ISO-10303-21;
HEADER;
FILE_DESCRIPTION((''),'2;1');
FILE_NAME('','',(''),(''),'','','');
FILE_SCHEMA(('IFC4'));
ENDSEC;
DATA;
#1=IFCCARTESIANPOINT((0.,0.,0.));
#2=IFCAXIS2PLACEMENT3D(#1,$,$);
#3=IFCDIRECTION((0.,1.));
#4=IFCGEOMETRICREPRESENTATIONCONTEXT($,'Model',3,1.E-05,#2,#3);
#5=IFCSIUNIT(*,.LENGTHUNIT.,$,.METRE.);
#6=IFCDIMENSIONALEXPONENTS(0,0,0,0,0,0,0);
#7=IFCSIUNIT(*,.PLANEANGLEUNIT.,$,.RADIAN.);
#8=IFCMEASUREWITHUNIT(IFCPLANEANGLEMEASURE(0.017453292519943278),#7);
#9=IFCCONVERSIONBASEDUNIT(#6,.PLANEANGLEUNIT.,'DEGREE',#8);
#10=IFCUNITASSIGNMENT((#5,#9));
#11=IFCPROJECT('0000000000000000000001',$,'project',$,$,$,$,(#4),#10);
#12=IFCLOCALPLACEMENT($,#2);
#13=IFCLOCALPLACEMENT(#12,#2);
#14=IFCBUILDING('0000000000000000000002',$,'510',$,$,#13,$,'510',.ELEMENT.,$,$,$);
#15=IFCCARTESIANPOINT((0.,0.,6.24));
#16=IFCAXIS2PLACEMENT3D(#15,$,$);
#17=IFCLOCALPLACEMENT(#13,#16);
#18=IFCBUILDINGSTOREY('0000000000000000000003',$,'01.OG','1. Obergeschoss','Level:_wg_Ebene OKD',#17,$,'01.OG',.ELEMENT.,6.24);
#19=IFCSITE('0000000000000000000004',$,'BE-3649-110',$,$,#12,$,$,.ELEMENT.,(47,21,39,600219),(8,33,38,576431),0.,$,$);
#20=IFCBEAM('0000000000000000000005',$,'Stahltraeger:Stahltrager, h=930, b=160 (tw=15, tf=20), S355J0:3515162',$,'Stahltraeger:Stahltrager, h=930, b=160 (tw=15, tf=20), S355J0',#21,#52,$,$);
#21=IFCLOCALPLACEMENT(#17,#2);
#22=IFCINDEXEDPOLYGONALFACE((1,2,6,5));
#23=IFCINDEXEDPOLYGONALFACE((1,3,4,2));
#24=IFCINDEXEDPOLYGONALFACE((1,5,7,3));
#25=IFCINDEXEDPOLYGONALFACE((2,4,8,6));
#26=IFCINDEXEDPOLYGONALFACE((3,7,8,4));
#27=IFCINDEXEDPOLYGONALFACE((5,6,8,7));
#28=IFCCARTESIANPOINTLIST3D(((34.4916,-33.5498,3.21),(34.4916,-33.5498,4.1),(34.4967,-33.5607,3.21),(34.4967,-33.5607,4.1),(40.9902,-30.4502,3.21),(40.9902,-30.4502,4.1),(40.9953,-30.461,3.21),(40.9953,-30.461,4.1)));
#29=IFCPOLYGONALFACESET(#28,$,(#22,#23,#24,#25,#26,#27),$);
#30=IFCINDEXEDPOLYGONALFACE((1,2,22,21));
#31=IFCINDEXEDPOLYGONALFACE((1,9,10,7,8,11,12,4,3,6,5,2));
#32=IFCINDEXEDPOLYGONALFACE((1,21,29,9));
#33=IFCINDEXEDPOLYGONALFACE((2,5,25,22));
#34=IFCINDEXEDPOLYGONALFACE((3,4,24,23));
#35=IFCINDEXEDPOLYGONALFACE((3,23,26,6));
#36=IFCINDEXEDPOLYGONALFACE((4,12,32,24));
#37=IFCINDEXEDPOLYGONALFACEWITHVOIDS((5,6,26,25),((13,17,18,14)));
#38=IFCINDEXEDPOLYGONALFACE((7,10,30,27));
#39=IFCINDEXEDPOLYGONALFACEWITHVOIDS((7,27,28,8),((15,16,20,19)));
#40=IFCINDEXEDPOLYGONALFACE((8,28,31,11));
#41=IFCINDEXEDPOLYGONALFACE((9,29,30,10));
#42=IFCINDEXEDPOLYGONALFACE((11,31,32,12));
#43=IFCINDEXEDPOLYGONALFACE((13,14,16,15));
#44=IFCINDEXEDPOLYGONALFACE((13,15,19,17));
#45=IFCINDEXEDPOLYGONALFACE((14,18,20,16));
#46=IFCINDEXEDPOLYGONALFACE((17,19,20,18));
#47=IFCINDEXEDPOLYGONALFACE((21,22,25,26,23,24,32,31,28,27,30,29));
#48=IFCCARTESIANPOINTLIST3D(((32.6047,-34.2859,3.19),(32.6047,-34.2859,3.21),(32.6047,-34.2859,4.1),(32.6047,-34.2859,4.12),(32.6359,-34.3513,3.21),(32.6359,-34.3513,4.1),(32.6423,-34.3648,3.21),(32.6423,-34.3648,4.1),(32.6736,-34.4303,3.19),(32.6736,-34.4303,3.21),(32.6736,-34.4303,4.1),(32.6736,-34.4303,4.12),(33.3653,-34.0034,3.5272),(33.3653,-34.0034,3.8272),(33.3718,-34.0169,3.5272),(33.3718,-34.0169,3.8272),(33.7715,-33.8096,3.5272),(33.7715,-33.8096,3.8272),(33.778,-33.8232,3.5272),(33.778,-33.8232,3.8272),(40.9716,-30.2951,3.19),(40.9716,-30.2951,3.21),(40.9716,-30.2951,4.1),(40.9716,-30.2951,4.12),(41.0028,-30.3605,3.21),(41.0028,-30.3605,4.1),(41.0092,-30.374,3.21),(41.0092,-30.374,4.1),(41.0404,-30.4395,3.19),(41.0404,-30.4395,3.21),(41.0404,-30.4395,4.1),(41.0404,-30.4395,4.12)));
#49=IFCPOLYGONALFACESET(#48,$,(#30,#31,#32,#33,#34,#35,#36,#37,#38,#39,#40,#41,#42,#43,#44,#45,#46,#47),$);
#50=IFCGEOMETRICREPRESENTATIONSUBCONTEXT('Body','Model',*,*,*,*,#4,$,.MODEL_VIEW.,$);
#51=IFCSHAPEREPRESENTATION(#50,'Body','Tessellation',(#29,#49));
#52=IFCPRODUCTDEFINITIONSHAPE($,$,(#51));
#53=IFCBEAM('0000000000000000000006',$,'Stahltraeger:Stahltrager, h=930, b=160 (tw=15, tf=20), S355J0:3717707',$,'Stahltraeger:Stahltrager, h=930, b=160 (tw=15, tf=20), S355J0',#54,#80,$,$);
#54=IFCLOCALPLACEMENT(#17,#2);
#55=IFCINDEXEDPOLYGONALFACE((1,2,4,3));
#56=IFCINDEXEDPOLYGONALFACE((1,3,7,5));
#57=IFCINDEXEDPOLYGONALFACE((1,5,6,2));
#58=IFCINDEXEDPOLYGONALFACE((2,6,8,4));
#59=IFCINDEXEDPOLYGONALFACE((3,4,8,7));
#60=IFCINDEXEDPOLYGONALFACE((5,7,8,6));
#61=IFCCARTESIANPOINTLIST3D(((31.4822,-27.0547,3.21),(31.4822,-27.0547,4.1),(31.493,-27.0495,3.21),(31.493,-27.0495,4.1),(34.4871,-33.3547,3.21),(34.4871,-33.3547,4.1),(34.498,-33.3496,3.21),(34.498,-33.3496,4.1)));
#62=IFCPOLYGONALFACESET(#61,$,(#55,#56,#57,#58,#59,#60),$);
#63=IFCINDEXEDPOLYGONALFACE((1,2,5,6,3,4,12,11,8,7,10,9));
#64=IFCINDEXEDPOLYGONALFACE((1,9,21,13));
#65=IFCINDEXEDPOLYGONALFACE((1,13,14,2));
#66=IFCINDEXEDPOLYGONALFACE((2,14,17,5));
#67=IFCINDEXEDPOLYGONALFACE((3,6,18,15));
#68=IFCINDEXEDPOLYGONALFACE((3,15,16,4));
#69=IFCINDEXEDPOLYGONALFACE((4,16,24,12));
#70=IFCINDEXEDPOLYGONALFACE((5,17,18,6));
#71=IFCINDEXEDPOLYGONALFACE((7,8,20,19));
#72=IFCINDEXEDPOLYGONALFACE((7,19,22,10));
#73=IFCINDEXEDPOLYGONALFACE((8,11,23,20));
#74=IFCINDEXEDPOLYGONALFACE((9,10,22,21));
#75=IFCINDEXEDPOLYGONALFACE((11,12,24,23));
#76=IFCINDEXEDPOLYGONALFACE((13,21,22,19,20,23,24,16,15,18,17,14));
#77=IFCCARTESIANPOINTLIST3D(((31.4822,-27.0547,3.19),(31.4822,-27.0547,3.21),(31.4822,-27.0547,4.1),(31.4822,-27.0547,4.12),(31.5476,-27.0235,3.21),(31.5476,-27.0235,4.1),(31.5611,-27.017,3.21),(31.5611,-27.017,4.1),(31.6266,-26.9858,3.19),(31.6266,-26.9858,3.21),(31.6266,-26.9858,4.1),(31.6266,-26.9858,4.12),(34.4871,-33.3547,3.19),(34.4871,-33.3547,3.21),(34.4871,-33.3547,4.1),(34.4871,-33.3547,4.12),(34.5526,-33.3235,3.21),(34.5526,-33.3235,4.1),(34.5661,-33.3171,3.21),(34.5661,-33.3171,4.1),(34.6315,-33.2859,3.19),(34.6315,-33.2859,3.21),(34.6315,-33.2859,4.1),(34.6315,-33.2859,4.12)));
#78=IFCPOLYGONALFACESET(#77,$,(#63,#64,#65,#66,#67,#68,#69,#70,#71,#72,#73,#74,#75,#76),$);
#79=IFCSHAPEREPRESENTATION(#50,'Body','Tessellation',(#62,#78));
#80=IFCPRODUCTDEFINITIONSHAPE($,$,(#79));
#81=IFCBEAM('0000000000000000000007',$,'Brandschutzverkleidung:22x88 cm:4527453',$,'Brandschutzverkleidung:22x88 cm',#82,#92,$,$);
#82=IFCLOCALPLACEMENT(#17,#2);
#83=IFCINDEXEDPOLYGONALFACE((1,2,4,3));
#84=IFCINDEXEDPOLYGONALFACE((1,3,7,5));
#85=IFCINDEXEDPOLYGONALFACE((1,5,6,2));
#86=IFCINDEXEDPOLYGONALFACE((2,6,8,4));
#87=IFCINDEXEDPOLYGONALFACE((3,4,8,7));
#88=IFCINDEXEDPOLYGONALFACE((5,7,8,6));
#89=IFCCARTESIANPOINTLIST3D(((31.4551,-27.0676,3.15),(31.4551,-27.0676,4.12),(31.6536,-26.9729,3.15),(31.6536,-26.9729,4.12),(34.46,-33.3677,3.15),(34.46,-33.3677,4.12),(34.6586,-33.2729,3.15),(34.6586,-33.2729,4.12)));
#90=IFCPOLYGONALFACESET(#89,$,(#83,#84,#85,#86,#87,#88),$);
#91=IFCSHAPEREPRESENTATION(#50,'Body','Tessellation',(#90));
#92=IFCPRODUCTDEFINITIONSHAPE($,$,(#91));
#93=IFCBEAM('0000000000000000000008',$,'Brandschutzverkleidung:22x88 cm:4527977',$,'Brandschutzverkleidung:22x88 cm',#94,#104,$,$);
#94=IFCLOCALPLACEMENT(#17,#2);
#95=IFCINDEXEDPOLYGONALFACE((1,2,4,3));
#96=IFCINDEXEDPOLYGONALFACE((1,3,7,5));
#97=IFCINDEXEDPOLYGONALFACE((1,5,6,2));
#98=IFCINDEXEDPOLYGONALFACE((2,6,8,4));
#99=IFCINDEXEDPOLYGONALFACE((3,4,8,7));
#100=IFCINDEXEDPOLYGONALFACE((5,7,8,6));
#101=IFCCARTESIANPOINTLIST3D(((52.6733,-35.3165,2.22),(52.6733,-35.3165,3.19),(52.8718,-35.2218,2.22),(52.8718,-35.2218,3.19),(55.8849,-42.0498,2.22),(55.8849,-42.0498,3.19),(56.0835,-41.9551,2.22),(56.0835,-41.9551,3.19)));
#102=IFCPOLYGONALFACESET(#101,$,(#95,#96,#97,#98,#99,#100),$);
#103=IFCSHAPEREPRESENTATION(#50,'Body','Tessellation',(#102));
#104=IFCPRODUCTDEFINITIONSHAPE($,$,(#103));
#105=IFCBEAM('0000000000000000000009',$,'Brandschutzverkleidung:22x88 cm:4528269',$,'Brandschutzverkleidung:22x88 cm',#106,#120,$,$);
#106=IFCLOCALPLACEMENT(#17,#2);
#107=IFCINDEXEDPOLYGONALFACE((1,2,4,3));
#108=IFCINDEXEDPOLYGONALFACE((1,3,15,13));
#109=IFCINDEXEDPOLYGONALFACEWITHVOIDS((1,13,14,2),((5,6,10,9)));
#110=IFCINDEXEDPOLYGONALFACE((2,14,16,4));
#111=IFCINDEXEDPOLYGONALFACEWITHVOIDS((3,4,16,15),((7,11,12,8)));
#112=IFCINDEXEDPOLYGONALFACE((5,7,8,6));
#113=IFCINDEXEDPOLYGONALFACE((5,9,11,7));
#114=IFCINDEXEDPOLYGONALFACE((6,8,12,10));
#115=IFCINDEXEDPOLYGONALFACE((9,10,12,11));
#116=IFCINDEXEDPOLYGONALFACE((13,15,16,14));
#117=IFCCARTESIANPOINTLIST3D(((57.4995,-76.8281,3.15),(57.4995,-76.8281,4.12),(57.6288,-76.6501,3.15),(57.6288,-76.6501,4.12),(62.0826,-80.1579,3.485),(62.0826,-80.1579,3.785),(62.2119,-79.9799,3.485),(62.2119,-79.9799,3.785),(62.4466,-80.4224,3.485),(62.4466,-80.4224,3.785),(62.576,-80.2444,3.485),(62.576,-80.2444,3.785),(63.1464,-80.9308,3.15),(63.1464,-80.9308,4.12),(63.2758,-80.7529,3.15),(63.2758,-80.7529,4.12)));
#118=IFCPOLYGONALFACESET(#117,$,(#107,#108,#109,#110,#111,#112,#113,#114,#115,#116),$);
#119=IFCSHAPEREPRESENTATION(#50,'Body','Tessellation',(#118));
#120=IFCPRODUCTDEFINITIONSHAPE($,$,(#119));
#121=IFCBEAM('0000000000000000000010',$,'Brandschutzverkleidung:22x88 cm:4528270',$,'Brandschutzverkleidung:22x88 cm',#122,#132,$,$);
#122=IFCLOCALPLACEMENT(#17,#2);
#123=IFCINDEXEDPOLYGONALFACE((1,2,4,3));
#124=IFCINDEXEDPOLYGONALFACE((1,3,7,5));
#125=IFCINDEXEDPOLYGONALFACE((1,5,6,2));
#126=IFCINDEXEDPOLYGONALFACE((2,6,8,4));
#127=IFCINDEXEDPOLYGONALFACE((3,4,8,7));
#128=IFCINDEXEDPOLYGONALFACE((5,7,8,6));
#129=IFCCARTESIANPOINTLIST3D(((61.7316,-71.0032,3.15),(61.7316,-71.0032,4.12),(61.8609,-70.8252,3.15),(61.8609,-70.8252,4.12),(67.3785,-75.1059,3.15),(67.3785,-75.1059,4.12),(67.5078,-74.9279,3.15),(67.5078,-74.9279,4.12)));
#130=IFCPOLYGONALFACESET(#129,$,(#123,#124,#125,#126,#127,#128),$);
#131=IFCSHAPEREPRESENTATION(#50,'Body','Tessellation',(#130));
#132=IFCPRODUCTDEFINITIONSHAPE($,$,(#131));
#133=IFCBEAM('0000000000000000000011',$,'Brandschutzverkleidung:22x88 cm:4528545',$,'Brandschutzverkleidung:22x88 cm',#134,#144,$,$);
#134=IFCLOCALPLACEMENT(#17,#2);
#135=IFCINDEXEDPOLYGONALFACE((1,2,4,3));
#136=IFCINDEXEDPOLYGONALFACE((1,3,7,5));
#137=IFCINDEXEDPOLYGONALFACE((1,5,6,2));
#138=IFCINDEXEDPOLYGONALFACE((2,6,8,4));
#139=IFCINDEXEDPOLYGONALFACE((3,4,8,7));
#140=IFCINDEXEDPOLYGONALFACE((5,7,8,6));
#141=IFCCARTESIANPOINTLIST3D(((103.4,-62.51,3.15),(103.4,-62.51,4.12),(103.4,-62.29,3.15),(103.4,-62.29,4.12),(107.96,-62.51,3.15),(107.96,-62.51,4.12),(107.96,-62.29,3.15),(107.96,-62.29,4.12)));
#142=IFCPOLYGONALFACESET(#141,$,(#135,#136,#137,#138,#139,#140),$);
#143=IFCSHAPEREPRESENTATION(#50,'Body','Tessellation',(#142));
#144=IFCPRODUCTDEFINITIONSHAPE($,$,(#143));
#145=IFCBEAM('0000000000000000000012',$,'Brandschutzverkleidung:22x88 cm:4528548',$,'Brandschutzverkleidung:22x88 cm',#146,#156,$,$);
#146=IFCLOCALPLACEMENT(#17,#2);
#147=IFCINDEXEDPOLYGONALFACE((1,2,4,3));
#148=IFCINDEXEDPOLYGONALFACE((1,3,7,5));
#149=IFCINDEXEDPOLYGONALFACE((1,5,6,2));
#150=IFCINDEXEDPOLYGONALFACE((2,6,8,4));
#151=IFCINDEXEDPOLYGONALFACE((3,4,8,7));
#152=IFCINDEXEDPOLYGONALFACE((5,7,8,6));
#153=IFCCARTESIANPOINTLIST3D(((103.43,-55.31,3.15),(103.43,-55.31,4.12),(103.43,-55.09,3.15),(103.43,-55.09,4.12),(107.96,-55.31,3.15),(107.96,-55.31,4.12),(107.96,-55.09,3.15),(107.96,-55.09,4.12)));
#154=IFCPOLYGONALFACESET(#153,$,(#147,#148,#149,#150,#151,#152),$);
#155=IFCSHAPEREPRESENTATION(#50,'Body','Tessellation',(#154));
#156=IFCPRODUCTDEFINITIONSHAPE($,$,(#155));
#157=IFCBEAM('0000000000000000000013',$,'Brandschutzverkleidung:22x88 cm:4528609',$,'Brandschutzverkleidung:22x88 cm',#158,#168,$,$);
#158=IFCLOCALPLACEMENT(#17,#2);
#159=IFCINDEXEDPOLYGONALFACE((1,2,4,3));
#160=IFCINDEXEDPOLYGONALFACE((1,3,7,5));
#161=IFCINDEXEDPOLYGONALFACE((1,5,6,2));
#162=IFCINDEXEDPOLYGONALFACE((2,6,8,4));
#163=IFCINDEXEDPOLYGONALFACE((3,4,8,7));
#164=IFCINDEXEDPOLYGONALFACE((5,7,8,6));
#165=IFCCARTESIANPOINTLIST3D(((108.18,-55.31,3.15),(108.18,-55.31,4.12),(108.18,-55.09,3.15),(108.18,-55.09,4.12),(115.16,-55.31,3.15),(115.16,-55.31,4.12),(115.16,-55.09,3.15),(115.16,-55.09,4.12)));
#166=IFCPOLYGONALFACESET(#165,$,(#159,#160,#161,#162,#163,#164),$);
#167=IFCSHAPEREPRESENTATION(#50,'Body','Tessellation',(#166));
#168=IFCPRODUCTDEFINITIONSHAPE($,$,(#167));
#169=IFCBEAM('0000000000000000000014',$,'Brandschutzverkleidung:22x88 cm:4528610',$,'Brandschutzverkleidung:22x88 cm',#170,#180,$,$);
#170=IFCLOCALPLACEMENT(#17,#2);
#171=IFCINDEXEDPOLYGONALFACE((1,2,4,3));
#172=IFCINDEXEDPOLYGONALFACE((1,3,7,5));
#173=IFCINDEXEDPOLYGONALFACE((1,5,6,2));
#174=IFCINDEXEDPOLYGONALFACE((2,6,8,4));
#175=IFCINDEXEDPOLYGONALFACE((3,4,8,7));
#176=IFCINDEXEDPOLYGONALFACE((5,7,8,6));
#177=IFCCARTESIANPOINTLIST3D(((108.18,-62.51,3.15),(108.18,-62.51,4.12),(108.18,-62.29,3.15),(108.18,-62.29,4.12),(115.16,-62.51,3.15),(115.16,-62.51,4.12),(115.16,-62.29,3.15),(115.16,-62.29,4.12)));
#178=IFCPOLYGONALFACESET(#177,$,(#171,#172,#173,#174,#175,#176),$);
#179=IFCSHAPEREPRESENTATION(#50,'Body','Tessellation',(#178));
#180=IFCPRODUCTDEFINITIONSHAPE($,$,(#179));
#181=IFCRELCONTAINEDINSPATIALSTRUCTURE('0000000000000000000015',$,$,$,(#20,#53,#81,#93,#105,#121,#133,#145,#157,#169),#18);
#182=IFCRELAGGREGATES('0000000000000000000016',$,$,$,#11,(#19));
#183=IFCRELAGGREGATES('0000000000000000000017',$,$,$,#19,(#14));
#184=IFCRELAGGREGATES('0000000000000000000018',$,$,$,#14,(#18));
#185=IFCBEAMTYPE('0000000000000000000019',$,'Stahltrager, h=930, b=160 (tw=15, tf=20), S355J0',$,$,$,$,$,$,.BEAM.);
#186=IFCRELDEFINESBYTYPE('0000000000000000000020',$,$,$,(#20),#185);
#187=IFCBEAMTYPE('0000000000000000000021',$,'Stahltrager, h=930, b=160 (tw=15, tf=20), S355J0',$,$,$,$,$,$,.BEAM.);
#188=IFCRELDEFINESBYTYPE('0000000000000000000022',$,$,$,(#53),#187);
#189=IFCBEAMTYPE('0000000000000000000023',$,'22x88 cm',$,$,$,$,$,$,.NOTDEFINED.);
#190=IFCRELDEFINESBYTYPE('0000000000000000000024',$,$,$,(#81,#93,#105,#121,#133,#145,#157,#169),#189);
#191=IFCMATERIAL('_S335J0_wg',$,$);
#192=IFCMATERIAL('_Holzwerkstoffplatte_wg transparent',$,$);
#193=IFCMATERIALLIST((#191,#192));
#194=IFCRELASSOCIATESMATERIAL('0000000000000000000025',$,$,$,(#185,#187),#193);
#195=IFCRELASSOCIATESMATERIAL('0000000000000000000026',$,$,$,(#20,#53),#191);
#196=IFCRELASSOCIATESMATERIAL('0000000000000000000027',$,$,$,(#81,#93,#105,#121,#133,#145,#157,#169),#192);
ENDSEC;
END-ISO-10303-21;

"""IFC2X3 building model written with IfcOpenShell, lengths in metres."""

from ifc_helpers import new_model, entity, si_unit, converted_unit, direction, frame, frame_2d, origin, origin_2d_with_axis, place, context, subcontext, project, spatial, polyline, rectangle, i_section, outline, extrude, boolean, source, transform, mapped, material, material_list, type_object, type_shapes, element, save


model = new_model("IFC2X3")

# Units and contexts
model_context = context("Model", 3, precision=1e-05, world=origin(), true_north=direction((0.0, 1.0)))
body_context = subcontext(model_context, "Body", "Model", "MODEL_VIEW")
ifc_project = project(units=[si_unit("LENGTHUNIT", "METRE"), converted_unit("PLANEANGLEUNIT", "DEGREE", entity("IfcPlaneAngleMeasure", 0.017453292519943278), si_unit("PLANEANGLEUNIT", "RADIAN"), dimensions=[0, 0, 0, 0, 0, 0, 0])], contexts=[model_context])

# Site, building, storey
site_placement = place(None, origin())
site = spatial("IfcSite", under=ifc_project, at=site_placement, Name="BE-3649-110", CompositionType="ELEMENT", RefLatitude=(47, 21, 39, 600219), RefLongitude=(8, 33, 38, 576431), RefElevation=0.0)
building_placement = place(site_placement, origin())
building = spatial("IfcBuilding", under=site, at=building_placement, Name="510", LongName="510", CompositionType="ELEMENT")
storey_placement = place(building_placement, frame((0.0, 0.0, 6.24)))
storey = spatial("IfcBuildingStorey", under=building, at=storey_placement, Name="01.OG", Description="1. Obergeschoss", ObjectType="Level:_wg_Ebene OKD", LongName="01.OG", CompositionType="ELEMENT", Elevation=6.24)

# Beams
ifc_material_1 = material(Name="_S335J0_wg")
ifc_material_2 = material(Name="_Holzwerkstoffplatte_wg transparent")
ifc_material_list = material_list([ifc_material_1, ifc_material_2])
beam_type_1 = type_object("IfcBeamType", Name="Stahltrager, h=930, b=160 (tw=15, tf=20), S355J0", PredefinedType="BEAM", material=ifc_material_list)
shared_shape_1 = source(origin(), body_context, "Body", "SweptSolid", [
    extrude(rectangle(XDim=0.89, YDim=0.012, at=frame_2d((0.0, 0.0), x_axis=(1.0, 0.0))), frame((40.9928, -30.4556, 9.895), z_axis=(-0.902585, -0.430511, 0.0), x_axis=(0.0, 0.0, -1.0)), (0.0, 0.0, 1.0), 7.2),
    boolean("DIFFERENCE", extrude(i_section(OverallWidth=0.16, OverallDepth=0.93, WebThickness=0.015, FlangeThickness=0.02, at=frame_2d((0.0, 0.0), x_axis=(0.0, 1.0))), frame((41.006, -30.3673, 9.895), z_axis=(-0.902585, -0.430511, 0.0), x_axis=(0.0, 0.0, -1.0)), (0.0, 0.0, 1.0), 9.2699), extrude(rectangle(XDim=0.3, YDim=0.45, at=frame_2d((0.0, 0.0), x_axis=(0.0, 1.0))), frame((33.5749, -33.92, 9.9172), z_axis=(-0.430511, 0.902585, 0.0), x_axis=(0.902585, 0.430511, 0.0)), (0.0, 0.0, 1.0), 0.015)),
])
type_shapes(beam_type_1, [shared_shape_1])
beam_1_placement = place(storey_placement, frame((0.0, 0.0, -6.24)))
element("IfcBeam", 1, at=beam_1_placement, inside=storey, type_object=beam_type_1, material=ifc_material_1, Name="Stahltraeger:Stahltrager, h=930, b=160 (tw=15, tf=20), S355J0:3515162", ObjectType="Stahltraeger:Stahltrager, h=930, b=160 (tw=15, tf=20), S355J0", context=body_context, shape_type="MappedRepresentation", body=[
    mapped(shared_shape_1, transform((0.0, 0.0, 0.0), scale=1.0)),
])
beam_type_2 = type_object("IfcBeamType", Name="Stahltrager, h=930, b=160 (tw=15, tf=20), S355J0", PredefinedType="BEAM", material=ifc_material_list)
shared_shape_2 = source(origin(), body_context, "Body", "SweptSolid", [
    extrude(rectangle(XDim=0.89, YDim=0.012, at=frame_2d((0.0, 0.0), x_axis=(1.0, 0.0))), frame((31.4876, -27.0521, 9.895), z_axis=(0.430511, -0.902585, 0.0), x_axis=(0.0, 0.0, -1.0)), (0.0, 0.0, 1.0), 6.98),
    extrude(i_section(OverallWidth=0.16, OverallDepth=0.93, WebThickness=0.015, FlangeThickness=0.02, at=frame_2d((0.0, 0.0), x_axis=(0.0, 1.0))), frame((31.5544, -27.0203, 9.895), z_axis=(0.430511, -0.902585, 0.0), x_axis=(0.0, 0.0, -1.0)), (0.0, 0.0, 1.0), 6.98),
])
type_shapes(beam_type_2, [shared_shape_2])
beam_2_placement = place(storey_placement, frame((0.0, 0.0, -6.24)))
element("IfcBeam", 2, at=beam_2_placement, inside=storey, type_object=beam_type_2, material=ifc_material_1, Name="Stahltraeger:Stahltrager, h=930, b=160 (tw=15, tf=20), S355J0:3717707", ObjectType="Stahltraeger:Stahltrager, h=930, b=160 (tw=15, tf=20), S355J0", context=body_context, shape_type="MappedRepresentation", body=[
    mapped(shared_shape_2, transform((0.0, 0.0, 0.0), scale=1.0)),
])
beam_type_3 = type_object("IfcBeamType", Name="22x88 cm", PredefinedType="NOTDEFINED")
beam_3_placement = place(storey_placement, frame((0.0, 0.0, 3.635)))
element("IfcBeam", 3, at=beam_3_placement, inside=storey, type_object=beam_type_3, material=ifc_material_2, Name="Brandschutzverkleidung:22x88 cm:4527453", ObjectType="Brandschutzverkleidung:22x88 cm", context=body_context, shape_type="SweptSolid", body=[
    extrude(rectangle(XDim=0.97, YDim=0.22, at=frame_2d((0.0, 0.0), x_axis=(0.0, 1.0))), frame((34.5593, -33.3203, 0.0), z_axis=(-0.430511, 0.902585, 0.0), x_axis=(0.902585, 0.430511, 0.0)), (0.0, 0.0, 1.0), 6.98),
])
beam_4_placement = place(storey_placement, frame((0.0, 0.0, 2.705)))
element("IfcBeam", 4, at=beam_4_placement, inside=storey, type_object=beam_type_3, material=ifc_material_2, Name="Brandschutzverkleidung:22x88 cm:4527977", ObjectType="Brandschutzverkleidung:22x88 cm", context=body_context, shape_type="SweptSolid", body=[
    extrude(rectangle(XDim=0.97, YDim=0.22, at=frame_2d((0.0, 0.1517), x_axis=(0.0, 1.0))), frame((55.9842, -42.0024, 0.1517), z_axis=(-0.430511, 0.902585, 0.0), x_axis=(0.902585, 0.430511, 0.0)), (0.0, 0.0, 1.0), 7.46),
])
beam_5_placement = place(storey_placement, frame((0.0, 0.0, 3.635)))
element("IfcBeam", 5, at=beam_5_placement, inside=storey, type_object=beam_type_3, material=ifc_material_2, Name="Brandschutzverkleidung:22x88 cm:4528269", ObjectType="Brandschutzverkleidung:22x88 cm", context=body_context, shape_type="SweptSolid", body=[
    extrude(outline(polyline([(-3.49, -0.485), (3.49, -0.485), (3.49, 0.485), (-3.49, 0.485), (-3.49, -0.485)]), holes=[polyline([(2.175, -0.15), (2.175, 0.15), (2.625, 0.15), (2.625, -0.15), (2.175, -0.15)])]), frame((60.323, -78.8795, 0.0), z_axis=(0.587785, 0.809017, 0.0), x_axis=(0.809017, -0.587785, 0.0)), (0.0, 0.0, 1.0), 0.22),
])
beam_6_placement = place(storey_placement, frame((0.0, 0.0, 3.635)))
element("IfcBeam", 6, at=beam_6_placement, inside=storey, type_object=beam_type_3, material=ifc_material_2, Name="Brandschutzverkleidung:22x88 cm:4528270", ObjectType="Brandschutzverkleidung:22x88 cm", context=body_context, shape_type="SweptSolid", body=[
    extrude(rectangle(XDim=0.97, YDim=0.22, at=origin_2d_with_axis()), frame((61.7962, -70.9142, 0.0), z_axis=(0.809017, -0.587785, 0.0), x_axis=(0.0, 0.0, -1.0)), (0.0, 0.0, 1.0), 6.98),
])
beam_7_placement = place(storey_placement, frame((0.0, 0.0, 3.635)))
element("IfcBeam", 7, at=beam_7_placement, inside=storey, type_object=beam_type_3, material=ifc_material_2, Name="Brandschutzverkleidung:22x88 cm:4528545", ObjectType="Brandschutzverkleidung:22x88 cm", context=body_context, shape_type="SweptSolid", body=[
    extrude(rectangle(XDim=0.97, YDim=0.22, at=origin_2d_with_axis()), frame((103.4, -62.4, 0.0), z_axis=(1.0, 0.0, 0.0), x_axis=(0.0, 0.0, -1.0)), (0.0, 0.0, 1.0), 4.56),
])
beam_8_placement = place(storey_placement, frame((0.0, 0.0, 3.635)))
element("IfcBeam", 8, at=beam_8_placement, inside=storey, type_object=beam_type_3, material=ifc_material_2, Name="Brandschutzverkleidung:22x88 cm:4528548", ObjectType="Brandschutzverkleidung:22x88 cm", context=body_context, shape_type="SweptSolid", body=[
    extrude(rectangle(XDim=0.97, YDim=0.22, at=origin_2d_with_axis()), frame((103.43, -55.2, 0.0), z_axis=(1.0, 0.0, 0.0), x_axis=(0.0, 0.0, -1.0)), (0.0, 0.0, 1.0), 4.53),
])
beam_9_placement = place(storey_placement, frame((0.0, 0.0, 3.635)))
element("IfcBeam", 9, at=beam_9_placement, inside=storey, type_object=beam_type_3, material=ifc_material_2, Name="Brandschutzverkleidung:22x88 cm:4528609", ObjectType="Brandschutzverkleidung:22x88 cm", context=body_context, shape_type="SweptSolid", body=[
    extrude(rectangle(XDim=0.97, YDim=0.22, at=origin_2d_with_axis()), frame((108.18, -55.2, 0.0), z_axis=(1.0, 0.0, 0.0), x_axis=(0.0, 0.0, -1.0)), (0.0, 0.0, 1.0), 6.98),
])
beam_10_placement = place(storey_placement, frame((0.0, 0.0, 3.635)))
element("IfcBeam", 10, at=beam_10_placement, inside=storey, type_object=beam_type_3, material=ifc_material_2, Name="Brandschutzverkleidung:22x88 cm:4528610", ObjectType="Brandschutzverkleidung:22x88 cm", context=body_context, shape_type="SweptSolid", body=[
    extrude(rectangle(XDim=0.97, YDim=0.22, at=origin_2d_with_axis()), frame((108.18, -62.4, 0.0), z_axis=(1.0, 0.0, 0.0), x_axis=(0.0, 0.0, -1.0)), (0.0, 0.0, 1.0), 6.98),
])

save(model, "model.ifc")
